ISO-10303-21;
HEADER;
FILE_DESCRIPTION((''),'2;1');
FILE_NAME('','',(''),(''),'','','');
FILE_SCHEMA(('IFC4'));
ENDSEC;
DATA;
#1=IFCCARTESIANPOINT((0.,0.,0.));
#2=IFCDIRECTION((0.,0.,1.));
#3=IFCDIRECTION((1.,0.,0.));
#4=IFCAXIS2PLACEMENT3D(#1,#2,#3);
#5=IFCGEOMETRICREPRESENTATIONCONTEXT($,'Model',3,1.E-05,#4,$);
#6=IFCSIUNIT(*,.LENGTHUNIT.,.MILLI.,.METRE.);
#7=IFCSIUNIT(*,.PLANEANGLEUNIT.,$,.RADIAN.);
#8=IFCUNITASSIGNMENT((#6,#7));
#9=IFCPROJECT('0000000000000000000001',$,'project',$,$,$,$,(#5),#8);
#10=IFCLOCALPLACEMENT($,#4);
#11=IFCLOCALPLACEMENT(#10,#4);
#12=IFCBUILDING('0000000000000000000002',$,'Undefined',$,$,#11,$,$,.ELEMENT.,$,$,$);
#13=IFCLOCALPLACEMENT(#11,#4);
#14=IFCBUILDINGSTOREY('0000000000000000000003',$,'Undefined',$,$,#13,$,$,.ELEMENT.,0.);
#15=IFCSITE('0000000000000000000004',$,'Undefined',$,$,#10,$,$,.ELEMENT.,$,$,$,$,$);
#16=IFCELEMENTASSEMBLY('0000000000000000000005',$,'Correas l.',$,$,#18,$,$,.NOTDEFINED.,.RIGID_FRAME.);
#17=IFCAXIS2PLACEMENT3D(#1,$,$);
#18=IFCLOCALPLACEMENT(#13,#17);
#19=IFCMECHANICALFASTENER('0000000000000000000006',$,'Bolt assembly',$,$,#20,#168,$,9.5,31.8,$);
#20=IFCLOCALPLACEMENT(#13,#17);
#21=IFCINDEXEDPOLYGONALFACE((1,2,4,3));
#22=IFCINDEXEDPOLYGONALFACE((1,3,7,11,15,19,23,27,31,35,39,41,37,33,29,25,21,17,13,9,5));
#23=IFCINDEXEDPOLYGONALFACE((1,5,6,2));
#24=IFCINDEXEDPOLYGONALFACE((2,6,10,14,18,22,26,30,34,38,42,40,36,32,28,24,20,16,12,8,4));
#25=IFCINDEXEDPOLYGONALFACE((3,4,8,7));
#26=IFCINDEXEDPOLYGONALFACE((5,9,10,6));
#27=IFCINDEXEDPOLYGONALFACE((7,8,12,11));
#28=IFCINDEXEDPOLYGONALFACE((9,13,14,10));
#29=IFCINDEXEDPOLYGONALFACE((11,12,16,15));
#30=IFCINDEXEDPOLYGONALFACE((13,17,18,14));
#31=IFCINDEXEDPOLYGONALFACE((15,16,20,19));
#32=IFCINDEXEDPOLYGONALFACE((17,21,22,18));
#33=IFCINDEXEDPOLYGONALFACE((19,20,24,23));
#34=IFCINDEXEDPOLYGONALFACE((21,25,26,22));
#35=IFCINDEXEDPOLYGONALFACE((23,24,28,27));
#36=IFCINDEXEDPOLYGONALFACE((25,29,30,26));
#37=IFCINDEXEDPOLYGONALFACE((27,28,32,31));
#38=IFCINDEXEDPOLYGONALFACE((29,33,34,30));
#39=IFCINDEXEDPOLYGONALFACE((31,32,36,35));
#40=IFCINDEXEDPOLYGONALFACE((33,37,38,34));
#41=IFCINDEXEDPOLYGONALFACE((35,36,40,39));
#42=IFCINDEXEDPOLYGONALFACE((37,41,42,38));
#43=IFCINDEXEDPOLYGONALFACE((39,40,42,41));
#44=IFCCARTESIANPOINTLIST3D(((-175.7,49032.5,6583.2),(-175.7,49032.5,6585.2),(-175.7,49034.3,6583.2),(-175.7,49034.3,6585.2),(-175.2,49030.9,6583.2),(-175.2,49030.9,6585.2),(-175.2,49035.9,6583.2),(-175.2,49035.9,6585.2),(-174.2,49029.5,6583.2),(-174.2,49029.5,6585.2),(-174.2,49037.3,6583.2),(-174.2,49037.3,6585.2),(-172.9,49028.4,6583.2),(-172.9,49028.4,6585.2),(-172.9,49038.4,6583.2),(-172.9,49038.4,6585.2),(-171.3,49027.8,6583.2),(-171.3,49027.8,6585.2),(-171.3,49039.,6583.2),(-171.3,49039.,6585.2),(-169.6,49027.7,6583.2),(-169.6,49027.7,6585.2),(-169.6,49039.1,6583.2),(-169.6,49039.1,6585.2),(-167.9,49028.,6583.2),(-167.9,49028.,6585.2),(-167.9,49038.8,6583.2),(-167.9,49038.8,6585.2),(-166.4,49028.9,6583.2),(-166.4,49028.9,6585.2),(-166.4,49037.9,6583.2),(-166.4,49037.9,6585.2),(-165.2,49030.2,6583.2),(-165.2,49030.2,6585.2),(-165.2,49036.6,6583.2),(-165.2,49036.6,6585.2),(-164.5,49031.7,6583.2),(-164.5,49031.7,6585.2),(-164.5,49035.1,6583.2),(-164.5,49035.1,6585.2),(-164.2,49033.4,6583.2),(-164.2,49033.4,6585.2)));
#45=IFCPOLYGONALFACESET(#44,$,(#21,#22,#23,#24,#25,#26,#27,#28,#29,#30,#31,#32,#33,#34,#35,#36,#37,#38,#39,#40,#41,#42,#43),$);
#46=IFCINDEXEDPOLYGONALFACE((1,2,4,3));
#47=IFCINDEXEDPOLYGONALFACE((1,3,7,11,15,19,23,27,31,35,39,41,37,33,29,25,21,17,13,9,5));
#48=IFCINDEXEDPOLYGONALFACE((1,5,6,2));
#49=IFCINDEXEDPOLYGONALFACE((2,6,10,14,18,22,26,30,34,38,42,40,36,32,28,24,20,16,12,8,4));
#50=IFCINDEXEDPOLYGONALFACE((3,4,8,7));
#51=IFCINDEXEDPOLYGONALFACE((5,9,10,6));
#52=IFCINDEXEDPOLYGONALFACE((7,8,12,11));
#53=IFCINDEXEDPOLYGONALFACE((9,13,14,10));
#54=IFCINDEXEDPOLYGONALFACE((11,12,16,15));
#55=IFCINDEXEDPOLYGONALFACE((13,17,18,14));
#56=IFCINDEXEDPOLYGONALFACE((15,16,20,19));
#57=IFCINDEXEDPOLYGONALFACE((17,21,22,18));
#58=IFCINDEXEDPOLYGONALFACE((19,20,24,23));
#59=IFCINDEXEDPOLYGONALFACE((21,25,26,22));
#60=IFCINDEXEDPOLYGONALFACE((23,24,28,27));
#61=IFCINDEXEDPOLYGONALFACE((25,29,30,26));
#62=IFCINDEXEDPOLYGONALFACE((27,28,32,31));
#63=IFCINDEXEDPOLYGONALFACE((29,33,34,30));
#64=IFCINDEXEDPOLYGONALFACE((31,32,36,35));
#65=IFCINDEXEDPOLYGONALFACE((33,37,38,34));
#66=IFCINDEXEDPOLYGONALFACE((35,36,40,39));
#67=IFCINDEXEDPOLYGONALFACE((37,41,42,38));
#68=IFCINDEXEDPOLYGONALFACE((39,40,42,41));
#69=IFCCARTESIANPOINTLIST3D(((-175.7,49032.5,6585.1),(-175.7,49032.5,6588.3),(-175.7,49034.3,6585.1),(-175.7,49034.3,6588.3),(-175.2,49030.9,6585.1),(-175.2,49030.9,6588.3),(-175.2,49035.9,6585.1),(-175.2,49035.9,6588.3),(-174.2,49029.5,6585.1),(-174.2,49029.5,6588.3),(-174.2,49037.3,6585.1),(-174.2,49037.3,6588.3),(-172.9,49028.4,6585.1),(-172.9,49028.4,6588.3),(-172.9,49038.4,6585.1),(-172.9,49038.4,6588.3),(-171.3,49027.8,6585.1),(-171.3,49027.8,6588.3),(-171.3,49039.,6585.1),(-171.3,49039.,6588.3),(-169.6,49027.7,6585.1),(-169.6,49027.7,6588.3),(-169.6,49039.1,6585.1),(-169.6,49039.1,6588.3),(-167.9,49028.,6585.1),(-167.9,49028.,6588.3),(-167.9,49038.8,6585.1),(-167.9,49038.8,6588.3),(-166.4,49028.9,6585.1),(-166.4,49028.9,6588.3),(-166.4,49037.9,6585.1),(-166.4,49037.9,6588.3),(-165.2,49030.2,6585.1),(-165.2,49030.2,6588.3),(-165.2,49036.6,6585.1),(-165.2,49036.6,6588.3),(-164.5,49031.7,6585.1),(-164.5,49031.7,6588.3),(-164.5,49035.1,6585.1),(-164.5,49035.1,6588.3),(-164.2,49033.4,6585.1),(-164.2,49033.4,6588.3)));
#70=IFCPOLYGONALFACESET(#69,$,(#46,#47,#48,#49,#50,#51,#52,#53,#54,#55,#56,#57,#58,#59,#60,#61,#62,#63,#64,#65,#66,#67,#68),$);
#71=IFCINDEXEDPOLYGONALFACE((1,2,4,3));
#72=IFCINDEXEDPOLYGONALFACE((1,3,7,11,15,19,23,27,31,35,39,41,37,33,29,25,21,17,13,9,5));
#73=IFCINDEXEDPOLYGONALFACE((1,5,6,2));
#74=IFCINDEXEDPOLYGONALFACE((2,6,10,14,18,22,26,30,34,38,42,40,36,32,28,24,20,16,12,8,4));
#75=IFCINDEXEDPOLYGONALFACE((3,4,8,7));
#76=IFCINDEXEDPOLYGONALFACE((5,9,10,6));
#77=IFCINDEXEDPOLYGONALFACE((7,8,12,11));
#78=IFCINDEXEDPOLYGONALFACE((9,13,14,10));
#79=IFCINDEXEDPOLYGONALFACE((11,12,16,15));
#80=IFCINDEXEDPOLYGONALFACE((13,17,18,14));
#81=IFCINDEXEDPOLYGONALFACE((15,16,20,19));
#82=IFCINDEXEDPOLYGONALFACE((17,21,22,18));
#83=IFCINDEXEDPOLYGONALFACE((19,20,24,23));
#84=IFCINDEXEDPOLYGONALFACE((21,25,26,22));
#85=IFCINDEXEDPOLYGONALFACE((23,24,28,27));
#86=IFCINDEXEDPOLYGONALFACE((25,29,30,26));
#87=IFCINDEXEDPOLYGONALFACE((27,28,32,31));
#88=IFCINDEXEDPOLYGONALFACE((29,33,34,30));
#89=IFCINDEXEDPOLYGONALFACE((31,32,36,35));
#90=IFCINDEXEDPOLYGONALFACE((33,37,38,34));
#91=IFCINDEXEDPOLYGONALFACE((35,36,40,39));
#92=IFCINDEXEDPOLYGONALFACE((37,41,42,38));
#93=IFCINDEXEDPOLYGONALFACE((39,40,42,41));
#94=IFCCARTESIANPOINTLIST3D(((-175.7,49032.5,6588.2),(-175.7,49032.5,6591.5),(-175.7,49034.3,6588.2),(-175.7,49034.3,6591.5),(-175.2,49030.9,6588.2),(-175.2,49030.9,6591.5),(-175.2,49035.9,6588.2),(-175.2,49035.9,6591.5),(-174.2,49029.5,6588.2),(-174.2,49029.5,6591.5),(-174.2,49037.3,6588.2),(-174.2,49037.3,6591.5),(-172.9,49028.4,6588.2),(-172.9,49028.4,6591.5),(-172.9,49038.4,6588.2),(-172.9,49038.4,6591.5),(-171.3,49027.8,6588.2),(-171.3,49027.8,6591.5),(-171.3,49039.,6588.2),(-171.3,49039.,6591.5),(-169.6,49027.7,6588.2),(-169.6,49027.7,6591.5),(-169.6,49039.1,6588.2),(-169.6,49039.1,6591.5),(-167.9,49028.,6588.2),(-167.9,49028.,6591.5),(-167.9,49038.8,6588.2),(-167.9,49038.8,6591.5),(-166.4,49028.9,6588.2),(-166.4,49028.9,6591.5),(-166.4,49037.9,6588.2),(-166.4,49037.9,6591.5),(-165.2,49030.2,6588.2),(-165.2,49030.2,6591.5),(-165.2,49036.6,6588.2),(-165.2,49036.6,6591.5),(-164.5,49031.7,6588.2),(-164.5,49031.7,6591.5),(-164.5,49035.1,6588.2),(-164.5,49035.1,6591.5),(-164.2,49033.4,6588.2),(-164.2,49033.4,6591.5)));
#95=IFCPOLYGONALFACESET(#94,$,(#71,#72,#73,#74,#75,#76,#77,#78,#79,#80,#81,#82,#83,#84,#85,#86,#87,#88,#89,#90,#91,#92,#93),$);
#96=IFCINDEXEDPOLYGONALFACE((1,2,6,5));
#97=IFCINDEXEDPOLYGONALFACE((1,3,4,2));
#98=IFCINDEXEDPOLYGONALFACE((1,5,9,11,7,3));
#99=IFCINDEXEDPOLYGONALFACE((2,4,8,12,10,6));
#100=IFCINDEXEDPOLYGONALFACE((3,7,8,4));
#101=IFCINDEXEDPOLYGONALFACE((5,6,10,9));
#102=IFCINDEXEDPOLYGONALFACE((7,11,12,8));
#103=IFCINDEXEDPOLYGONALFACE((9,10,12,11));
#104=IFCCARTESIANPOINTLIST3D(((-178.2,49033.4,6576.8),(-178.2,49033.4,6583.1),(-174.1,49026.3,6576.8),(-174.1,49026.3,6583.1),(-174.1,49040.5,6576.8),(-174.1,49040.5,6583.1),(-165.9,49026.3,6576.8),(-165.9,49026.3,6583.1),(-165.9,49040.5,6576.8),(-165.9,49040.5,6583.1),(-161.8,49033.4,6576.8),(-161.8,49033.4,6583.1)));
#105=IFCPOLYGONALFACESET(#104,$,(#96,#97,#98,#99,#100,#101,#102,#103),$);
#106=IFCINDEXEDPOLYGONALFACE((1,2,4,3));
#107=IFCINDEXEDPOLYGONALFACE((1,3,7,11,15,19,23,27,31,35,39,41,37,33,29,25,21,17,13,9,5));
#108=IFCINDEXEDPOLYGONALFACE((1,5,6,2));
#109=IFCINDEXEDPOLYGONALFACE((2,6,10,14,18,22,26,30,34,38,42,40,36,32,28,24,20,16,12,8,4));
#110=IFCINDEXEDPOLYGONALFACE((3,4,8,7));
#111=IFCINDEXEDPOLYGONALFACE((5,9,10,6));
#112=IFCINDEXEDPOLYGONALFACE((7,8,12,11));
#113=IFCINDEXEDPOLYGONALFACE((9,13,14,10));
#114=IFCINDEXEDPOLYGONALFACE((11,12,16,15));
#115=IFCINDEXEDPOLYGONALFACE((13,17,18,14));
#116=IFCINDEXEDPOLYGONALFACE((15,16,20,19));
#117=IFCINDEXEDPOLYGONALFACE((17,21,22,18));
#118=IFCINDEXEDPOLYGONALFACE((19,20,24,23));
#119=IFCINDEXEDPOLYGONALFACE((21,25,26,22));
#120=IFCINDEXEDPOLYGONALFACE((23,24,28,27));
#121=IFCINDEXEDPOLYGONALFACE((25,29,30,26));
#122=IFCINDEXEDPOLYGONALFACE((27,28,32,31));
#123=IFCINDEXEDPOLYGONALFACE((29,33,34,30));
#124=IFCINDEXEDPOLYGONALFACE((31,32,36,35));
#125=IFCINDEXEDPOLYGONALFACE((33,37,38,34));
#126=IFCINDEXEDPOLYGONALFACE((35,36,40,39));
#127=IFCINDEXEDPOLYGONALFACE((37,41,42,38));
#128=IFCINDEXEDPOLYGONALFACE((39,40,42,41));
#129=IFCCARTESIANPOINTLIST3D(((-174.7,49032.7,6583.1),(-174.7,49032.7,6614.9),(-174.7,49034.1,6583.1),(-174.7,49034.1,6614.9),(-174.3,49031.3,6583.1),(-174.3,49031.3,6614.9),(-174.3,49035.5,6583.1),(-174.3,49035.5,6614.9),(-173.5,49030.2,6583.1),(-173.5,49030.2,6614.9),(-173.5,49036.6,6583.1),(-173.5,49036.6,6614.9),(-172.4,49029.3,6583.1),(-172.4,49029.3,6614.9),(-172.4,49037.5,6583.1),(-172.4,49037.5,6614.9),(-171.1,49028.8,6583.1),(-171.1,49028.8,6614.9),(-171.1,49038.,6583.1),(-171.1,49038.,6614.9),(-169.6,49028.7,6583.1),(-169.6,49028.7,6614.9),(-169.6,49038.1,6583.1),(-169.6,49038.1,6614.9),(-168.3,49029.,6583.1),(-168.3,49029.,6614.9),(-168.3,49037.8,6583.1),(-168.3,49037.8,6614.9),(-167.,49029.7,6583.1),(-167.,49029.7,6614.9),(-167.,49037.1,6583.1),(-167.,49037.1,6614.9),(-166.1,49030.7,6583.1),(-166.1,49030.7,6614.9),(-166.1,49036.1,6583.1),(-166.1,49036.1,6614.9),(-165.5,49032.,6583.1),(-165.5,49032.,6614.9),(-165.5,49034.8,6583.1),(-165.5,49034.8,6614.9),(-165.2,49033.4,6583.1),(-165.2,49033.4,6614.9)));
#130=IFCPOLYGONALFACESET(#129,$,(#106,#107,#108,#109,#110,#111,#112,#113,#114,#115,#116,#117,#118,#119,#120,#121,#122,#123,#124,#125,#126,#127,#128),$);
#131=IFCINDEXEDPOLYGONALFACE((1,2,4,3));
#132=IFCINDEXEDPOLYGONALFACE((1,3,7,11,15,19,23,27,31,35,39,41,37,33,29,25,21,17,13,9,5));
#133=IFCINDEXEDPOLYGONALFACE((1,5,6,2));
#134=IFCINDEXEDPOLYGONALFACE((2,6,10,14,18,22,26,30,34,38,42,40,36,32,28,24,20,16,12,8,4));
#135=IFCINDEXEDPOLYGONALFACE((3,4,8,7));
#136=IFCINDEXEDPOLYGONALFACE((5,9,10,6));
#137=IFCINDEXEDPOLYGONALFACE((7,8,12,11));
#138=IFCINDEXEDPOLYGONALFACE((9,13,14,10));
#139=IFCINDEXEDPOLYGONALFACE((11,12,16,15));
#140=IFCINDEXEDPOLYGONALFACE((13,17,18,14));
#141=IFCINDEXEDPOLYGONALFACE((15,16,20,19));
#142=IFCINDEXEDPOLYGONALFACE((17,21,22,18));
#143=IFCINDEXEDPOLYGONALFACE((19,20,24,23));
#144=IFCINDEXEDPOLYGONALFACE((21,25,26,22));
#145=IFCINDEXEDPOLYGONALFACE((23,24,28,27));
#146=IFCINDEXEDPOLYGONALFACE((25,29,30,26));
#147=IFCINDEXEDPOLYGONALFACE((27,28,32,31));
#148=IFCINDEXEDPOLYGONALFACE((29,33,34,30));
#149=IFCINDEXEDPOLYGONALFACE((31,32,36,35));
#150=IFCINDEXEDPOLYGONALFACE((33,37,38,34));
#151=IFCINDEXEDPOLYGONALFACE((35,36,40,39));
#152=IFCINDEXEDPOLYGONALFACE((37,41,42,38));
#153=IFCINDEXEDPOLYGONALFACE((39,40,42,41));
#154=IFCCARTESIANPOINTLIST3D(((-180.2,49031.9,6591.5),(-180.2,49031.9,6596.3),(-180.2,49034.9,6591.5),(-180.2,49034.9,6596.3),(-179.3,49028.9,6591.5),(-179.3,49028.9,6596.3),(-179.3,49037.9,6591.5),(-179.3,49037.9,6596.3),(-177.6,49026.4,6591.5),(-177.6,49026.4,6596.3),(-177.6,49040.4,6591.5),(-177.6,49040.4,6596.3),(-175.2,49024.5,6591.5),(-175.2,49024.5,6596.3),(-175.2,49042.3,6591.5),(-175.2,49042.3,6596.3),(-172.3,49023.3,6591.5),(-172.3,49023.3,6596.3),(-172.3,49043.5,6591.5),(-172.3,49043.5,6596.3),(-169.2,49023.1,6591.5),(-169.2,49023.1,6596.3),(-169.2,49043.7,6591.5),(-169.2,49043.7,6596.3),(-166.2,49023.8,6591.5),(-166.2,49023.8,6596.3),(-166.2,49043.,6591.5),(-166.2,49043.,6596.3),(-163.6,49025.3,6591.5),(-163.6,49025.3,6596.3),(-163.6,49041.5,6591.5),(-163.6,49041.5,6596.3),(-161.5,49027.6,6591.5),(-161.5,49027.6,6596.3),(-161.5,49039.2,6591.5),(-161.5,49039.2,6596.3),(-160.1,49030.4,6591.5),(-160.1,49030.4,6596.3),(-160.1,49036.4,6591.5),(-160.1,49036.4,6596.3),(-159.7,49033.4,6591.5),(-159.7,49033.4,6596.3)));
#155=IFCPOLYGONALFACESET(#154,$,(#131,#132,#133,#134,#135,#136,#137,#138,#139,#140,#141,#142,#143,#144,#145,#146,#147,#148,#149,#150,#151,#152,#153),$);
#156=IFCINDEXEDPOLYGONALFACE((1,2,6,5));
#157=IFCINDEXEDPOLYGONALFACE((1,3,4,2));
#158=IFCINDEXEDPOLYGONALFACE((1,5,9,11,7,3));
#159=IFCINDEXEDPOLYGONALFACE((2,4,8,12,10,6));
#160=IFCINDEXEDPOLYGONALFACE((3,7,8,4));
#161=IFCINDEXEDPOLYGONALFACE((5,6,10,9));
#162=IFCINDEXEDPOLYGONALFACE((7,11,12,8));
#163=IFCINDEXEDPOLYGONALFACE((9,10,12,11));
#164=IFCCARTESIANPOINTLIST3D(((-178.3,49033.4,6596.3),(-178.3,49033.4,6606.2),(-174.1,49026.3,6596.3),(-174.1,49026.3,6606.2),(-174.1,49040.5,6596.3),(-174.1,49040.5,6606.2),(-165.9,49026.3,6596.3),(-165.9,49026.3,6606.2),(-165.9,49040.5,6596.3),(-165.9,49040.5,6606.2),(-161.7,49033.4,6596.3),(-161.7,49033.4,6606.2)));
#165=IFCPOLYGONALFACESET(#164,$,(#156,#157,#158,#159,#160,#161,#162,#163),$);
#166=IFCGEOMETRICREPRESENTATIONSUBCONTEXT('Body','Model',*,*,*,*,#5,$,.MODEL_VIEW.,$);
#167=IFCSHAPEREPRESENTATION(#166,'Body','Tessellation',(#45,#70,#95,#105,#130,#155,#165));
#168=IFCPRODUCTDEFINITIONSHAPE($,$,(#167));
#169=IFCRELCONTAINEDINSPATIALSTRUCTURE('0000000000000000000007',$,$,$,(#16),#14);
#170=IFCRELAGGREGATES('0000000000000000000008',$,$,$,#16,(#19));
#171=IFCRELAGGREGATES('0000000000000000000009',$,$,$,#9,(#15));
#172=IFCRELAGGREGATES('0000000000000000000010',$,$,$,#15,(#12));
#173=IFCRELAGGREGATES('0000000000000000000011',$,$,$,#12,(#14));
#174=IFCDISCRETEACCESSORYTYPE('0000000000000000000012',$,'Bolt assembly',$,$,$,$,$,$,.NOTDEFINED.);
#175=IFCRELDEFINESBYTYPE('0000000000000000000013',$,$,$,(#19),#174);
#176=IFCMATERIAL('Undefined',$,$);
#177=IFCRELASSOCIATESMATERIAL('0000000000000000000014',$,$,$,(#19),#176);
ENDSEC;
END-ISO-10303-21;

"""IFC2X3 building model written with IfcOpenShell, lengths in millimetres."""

from ifc_helpers import new_model, si_unit, frame, origin_with_axes, origin_2d_with_axis, place, context, subcontext, project, spatial, polyline, circle, outline, extrude, source, transform, mapped, material, type_object, element, aggregate, save


model = new_model("IFC2X3")

# Units and contexts
model_context = context("Model", 3, precision=1e-05, world=origin_with_axes())
body_context = subcontext(model_context, "Body", "Model", "MODEL_VIEW")
ifc_project = project(units=[si_unit("LENGTHUNIT", "METRE", prefix="MILLI"), si_unit("PLANEANGLEUNIT", "RADIAN")], contexts=[model_context])

# Site, building, storey
site_placement = place(None, origin_with_axes())
site = spatial("IfcSite", under=ifc_project, at=site_placement, Name="Undefined", CompositionType="ELEMENT")
building_placement = place(site_placement, origin_with_axes())
building = spatial("IfcBuilding", under=site, at=building_placement, Name="Undefined", CompositionType="ELEMENT")
storey_placement = place(building_placement, origin_with_axes())
storey = spatial("IfcBuildingStorey", under=building, at=storey_placement, Name="Undefined", CompositionType="ELEMENT", Elevation=0.0)

# Element assembly
assembly_1_placement = place(storey_placement, origin_with_axes())
assembly_1 = element("IfcElementAssembly", 1, at=assembly_1_placement, inside=storey, Name="Correas l.", AssemblyPlace="NOTDEFINED", PredefinedType="RIGID_FRAME")

# Shared definitions
discrete_accessory_type_1 = type_object("IfcDiscreteAccessoryType", Name="Bolt assembly")

# Mechanical fastener
ifc_material_1 = material(Name="Undefined")
shared_shape_1 = source(origin_with_axes(), body_context, "Body", "SweptSolid", [
    extrude(circle(Radius=5.8, at=origin_2d_with_axis()), frame((0.0, -5.1, 0.0), z_axis=(0.0, 1.0, 0.0), x_axis=(1.0, 0.0, 0.0)), (0.0, 0.0, 1.0), 2.0),
    extrude(circle(Radius=5.8, at=origin_2d_with_axis()), frame((0.0, -3.2, 0.0), z_axis=(0.0, 1.0, 0.0), x_axis=(1.0, 0.0, 0.0)), (0.0, 0.0, 1.0), 3.2),
    extrude(circle(Radius=5.8, at=origin_2d_with_axis()), frame((0.0, -0.1, 0.0), z_axis=(0.0, 1.0, 0.0), x_axis=(1.0, 0.0, 0.0)), (0.0, 0.0, 1.0), 3.3),
    extrude(outline(polyline([(8.2, 0.0), (4.1, 7.1), (-4.1, 7.1), (-8.2, 0.0), (-4.1, -7.1), (4.1, -7.1), (8.2, 0.0)])), frame((0.0, -11.5, 0.0), z_axis=(0.0, 1.0, 0.0), x_axis=(1.0, 0.0, 0.0)), (0.0, 0.0, 1.0), 6.3),
    extrude(circle(Radius=4.8, at=origin_2d_with_axis()), frame((0.0, -5.2, 0.0), z_axis=(0.0, 1.0, 0.0), x_axis=(1.0, 0.0, 0.0)), (0.0, 0.0, 1.0), 31.8),
    extrude(circle(Radius=10.3, at=origin_2d_with_axis()), frame((0.0, 3.2, 0.0), z_axis=(0.0, 1.0, 0.0), x_axis=(1.0, 0.0, 0.0)), (0.0, 0.0, 1.0), 4.8),
    extrude(outline(polyline([(8.3, 0.0), (4.1, 7.1), (-4.1, 7.1), (-8.3, 0.0), (-4.1, -7.1), (4.1, -7.1), (8.3, 0.0)])), frame((0.0, 8.0, 0.0), z_axis=(0.0, 1.0, 0.0), x_axis=(1.0, 0.0, 0.0)), (0.0, 0.0, 1.0), 9.9),
])
mechanical_fastener_1_placement = place(assembly_1_placement, frame((-230.0, 49033.4, 6588.3), z_axis=(0.0, -1.0, 0.0), x_axis=(1.0, 0.0, 0.0)))
mechanical_fastener_1 = element("IfcMechanicalFastener", 2, at=mechanical_fastener_1_placement, type_object=discrete_accessory_type_1, material=ifc_material_1, Name="Bolt assembly", NominalDiameter=9.5, NominalLength=31.8, context=body_context, shape_type="MappedRepresentation", body=[
    mapped(shared_shape_1, transform((60.0, 0.0, 0.0))),
])
aggregate(assembly_1, [mechanical_fastener_1])

save(model, "model.ifc")
